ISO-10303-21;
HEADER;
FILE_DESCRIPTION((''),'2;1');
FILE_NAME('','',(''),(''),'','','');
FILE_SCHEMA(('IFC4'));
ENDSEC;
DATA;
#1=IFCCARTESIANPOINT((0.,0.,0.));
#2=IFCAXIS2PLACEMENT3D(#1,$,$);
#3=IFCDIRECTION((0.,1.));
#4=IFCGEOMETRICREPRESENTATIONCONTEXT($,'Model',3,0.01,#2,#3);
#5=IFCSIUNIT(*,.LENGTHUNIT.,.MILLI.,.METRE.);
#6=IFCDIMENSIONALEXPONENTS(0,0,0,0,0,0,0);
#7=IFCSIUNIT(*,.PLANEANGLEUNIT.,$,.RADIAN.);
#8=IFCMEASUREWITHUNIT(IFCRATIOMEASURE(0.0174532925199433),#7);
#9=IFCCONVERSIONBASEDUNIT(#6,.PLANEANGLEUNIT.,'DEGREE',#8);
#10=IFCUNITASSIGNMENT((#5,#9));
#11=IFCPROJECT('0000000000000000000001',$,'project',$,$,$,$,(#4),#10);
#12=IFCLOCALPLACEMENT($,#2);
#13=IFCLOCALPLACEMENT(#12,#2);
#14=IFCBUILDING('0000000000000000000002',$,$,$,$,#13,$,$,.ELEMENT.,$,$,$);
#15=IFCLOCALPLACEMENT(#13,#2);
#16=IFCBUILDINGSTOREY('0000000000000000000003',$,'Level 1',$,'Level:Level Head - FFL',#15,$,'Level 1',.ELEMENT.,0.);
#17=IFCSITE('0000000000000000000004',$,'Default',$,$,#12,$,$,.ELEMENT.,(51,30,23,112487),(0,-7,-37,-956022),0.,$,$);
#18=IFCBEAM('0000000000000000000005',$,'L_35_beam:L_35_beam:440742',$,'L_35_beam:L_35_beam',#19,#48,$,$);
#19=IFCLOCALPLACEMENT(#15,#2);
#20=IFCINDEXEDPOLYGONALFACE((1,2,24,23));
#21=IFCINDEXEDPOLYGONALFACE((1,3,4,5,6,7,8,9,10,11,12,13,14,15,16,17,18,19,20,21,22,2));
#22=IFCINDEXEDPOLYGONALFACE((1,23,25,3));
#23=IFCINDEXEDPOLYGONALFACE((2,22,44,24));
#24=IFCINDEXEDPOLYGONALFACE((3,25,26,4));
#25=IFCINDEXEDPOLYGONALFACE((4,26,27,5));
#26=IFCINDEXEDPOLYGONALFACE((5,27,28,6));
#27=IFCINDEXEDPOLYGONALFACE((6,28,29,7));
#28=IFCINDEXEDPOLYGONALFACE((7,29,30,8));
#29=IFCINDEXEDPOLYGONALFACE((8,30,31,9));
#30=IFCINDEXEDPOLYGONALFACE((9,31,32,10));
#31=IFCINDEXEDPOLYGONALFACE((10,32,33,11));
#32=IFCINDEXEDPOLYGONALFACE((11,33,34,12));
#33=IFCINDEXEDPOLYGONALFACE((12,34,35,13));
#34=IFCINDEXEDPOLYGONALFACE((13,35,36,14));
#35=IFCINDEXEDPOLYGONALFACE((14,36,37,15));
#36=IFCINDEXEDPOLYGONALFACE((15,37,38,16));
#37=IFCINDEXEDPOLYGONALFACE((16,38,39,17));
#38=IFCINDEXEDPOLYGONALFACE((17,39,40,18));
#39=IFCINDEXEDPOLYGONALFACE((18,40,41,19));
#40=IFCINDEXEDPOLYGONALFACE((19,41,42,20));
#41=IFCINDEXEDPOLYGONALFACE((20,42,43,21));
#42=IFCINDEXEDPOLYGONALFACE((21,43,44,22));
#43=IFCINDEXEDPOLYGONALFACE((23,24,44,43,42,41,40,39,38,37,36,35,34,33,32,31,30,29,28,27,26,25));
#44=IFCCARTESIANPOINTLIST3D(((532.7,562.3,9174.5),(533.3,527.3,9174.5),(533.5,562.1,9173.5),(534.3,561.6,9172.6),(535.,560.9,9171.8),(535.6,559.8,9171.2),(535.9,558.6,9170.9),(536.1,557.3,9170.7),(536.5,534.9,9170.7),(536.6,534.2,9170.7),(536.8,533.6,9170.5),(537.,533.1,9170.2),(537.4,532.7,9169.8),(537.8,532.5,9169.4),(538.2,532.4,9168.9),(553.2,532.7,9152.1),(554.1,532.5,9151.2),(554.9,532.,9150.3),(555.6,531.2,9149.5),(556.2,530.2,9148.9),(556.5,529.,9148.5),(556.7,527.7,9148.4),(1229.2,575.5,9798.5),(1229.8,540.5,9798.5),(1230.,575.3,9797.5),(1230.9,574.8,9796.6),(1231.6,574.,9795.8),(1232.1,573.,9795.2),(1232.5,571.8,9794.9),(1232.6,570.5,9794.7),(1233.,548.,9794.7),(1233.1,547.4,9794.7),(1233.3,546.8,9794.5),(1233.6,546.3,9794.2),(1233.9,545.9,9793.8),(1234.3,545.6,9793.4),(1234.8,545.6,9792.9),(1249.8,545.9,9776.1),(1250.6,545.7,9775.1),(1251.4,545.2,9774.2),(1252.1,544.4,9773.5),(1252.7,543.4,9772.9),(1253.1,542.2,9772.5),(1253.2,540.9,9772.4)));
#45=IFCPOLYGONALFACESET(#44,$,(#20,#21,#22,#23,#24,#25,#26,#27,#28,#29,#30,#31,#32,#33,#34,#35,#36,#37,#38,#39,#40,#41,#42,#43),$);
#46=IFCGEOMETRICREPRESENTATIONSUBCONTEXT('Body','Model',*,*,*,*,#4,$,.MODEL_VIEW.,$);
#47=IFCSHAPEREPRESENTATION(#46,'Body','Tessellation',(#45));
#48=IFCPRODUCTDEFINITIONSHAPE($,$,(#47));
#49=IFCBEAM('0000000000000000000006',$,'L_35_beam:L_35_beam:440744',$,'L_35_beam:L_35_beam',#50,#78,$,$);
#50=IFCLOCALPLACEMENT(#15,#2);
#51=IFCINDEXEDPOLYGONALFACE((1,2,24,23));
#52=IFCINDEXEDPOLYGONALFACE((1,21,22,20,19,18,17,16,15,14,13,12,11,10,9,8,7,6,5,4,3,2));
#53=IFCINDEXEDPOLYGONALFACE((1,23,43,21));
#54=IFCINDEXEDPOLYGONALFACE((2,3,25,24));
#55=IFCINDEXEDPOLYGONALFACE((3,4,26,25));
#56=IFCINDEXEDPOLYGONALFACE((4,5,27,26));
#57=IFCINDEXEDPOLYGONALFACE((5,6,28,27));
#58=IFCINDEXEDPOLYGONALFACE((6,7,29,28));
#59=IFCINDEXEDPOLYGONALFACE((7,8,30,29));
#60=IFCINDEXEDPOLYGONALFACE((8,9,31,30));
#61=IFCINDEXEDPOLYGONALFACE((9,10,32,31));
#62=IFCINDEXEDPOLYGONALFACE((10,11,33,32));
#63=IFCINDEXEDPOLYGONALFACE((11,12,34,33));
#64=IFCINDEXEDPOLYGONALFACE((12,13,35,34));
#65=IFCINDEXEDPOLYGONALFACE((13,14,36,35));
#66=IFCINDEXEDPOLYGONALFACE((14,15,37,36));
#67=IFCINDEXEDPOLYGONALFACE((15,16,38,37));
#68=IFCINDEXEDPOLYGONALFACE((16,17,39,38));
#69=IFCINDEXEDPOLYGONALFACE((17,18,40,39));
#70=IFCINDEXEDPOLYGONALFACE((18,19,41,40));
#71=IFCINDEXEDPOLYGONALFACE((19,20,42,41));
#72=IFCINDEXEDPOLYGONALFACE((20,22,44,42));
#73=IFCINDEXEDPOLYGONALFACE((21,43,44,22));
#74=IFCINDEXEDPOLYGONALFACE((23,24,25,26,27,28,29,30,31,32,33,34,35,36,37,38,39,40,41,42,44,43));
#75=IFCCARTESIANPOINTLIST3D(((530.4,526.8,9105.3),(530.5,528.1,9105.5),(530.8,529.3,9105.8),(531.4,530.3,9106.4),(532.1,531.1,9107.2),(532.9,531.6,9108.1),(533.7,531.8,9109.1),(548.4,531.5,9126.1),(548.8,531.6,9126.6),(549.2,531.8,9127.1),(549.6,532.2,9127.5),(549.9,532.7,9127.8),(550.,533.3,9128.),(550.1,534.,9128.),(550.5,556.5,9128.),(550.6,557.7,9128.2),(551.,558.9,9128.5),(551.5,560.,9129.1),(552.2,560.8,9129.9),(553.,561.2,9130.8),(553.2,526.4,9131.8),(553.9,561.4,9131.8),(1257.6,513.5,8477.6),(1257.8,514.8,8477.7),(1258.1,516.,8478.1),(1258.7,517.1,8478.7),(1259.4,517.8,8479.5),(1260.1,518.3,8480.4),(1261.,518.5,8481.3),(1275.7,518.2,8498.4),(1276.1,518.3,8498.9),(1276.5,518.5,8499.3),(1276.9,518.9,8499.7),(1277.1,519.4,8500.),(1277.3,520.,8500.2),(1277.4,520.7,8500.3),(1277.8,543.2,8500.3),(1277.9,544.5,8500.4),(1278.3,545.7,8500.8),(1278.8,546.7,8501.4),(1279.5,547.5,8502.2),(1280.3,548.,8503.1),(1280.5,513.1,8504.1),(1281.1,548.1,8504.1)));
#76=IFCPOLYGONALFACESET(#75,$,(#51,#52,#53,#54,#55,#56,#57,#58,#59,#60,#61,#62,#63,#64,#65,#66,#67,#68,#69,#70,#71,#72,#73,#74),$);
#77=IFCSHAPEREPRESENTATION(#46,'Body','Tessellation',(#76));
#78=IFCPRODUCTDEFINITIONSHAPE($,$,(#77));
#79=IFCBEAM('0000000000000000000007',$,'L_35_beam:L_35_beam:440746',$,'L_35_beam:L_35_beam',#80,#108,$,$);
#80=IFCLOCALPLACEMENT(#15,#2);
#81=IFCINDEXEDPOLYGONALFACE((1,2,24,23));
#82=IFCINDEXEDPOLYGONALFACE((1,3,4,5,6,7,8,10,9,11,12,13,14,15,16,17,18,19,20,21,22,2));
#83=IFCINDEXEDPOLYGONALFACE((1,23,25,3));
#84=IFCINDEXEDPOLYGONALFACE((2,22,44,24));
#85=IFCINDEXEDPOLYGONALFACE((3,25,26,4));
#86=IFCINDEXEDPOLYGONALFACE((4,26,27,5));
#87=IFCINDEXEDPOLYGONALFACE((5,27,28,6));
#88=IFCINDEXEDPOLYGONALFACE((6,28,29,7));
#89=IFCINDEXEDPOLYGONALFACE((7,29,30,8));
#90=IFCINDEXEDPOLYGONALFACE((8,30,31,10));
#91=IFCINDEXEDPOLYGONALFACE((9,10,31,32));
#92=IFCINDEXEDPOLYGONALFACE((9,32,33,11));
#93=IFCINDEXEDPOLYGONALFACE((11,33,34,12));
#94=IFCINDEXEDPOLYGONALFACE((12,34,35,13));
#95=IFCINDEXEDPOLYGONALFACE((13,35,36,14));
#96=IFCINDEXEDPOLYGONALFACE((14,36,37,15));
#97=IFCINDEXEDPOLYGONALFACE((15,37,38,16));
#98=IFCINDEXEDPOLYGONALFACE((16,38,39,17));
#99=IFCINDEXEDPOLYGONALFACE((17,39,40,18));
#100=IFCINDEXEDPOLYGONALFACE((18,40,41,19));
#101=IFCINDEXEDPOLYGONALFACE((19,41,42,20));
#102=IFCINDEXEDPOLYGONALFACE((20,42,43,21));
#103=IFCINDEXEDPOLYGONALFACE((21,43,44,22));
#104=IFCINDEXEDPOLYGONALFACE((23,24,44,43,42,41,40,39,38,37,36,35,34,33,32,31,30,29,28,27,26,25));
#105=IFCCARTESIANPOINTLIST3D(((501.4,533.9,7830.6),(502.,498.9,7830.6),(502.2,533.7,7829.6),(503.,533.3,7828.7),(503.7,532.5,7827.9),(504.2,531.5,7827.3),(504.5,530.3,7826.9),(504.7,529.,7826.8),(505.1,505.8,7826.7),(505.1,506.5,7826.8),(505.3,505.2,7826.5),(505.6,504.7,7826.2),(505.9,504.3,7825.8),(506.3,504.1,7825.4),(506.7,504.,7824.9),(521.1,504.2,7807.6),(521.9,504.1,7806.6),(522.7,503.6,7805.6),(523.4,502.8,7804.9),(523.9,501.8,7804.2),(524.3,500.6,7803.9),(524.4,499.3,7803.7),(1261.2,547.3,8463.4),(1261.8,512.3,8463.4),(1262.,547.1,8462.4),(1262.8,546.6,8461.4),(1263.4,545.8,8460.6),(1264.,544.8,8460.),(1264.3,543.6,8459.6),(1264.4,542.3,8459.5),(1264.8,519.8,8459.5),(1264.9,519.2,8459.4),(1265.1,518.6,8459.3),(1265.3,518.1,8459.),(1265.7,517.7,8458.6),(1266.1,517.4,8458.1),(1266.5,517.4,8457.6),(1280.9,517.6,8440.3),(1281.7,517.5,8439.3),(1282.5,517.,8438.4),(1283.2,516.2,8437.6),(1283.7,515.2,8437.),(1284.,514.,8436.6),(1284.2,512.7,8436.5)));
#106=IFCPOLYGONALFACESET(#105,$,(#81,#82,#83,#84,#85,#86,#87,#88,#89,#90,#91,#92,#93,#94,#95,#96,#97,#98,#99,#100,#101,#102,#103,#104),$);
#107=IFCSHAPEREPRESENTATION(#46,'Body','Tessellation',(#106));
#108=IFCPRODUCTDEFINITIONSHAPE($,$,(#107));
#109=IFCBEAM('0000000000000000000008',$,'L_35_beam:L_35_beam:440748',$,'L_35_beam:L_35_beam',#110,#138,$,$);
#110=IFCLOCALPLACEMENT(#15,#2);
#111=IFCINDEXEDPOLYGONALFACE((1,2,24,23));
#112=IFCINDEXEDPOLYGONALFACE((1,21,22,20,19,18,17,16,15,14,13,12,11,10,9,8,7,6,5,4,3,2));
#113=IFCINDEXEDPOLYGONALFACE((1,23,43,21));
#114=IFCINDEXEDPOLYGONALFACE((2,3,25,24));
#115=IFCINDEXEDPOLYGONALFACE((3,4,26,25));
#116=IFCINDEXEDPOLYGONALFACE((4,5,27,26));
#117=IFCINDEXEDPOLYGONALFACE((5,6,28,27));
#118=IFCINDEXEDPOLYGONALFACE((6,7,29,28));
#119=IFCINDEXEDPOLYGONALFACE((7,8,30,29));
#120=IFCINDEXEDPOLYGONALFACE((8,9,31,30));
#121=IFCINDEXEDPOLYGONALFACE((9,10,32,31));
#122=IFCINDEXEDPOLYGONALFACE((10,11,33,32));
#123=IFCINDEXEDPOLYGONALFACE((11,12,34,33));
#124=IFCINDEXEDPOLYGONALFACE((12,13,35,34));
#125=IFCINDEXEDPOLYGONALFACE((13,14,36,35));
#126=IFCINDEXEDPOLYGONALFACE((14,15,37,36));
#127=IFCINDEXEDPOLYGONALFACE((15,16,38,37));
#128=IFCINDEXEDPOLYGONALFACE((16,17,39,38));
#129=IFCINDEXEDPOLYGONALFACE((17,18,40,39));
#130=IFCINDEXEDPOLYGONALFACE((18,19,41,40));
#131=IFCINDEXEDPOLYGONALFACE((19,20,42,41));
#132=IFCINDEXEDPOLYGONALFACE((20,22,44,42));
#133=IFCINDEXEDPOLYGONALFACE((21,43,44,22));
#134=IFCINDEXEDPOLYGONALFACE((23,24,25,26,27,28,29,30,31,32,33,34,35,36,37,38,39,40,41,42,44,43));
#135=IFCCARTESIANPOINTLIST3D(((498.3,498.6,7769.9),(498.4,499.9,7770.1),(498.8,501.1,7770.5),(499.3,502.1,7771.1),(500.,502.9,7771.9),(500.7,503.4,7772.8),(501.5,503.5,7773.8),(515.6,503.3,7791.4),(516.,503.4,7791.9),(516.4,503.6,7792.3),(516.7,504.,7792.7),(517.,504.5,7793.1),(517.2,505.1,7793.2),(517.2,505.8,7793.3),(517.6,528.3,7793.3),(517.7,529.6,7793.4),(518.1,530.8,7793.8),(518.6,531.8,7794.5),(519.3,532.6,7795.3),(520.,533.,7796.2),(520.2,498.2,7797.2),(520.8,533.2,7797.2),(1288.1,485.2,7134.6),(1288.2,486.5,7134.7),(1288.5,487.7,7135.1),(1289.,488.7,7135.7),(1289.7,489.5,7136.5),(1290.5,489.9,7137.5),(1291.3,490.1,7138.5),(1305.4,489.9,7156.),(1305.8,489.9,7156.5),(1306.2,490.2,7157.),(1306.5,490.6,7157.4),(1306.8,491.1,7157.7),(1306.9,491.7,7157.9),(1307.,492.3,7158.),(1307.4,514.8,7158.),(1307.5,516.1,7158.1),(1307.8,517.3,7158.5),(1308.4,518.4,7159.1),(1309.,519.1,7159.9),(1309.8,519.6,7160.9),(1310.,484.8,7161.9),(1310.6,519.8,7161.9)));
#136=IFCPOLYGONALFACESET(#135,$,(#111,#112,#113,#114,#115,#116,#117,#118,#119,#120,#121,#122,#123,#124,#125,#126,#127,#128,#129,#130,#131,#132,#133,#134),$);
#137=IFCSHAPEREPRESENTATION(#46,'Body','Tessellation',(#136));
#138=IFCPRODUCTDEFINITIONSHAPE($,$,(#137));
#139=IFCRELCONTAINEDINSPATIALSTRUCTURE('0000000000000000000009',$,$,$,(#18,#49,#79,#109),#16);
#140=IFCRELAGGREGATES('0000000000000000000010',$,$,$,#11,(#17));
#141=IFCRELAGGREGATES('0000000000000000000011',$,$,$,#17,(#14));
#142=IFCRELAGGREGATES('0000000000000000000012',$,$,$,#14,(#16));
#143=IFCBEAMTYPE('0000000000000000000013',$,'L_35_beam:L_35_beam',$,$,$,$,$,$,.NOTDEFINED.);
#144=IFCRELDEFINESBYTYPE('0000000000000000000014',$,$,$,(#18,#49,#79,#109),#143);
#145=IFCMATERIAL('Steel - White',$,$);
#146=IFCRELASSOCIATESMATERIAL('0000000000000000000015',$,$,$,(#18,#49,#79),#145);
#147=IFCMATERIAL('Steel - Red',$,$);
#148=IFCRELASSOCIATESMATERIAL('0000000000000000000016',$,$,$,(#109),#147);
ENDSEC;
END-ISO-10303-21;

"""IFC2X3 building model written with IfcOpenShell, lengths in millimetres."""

from ifc_helpers import new_model, entity, si_unit, converted_unit, direction, frame, frame_2d, origin, place, context, subcontext, project, spatial, polyline, circle_curve, parameter, trimmed, segment, composite_curve, outline, extrude, material, type_object, element, save


model = new_model("IFC2X3")

# Units and contexts
model_context = context("Model", 3, precision=0.01, world=origin(), true_north=direction((0.0, 1.0)))
body_context = subcontext(model_context, "Body", "Model", "MODEL_VIEW")
ifc_project = project(units=[si_unit("LENGTHUNIT", "METRE", prefix="MILLI"), converted_unit("PLANEANGLEUNIT", "DEGREE", entity("IfcRatioMeasure", 0.0174532925199433), si_unit("PLANEANGLEUNIT", "RADIAN"), dimensions=[0, 0, 0, 0, 0, 0, 0])], contexts=[model_context])

# Site, building, storey
site_placement = place(None, origin())
site = spatial("IfcSite", under=ifc_project, at=site_placement, Name="Default", CompositionType="ELEMENT", RefLatitude=(51, 30, 23, 112487), RefLongitude=(0, -7, -37, -956022), RefElevation=0.0)
building_placement = place(site_placement, origin())
building = spatial("IfcBuilding", under=site, at=building_placement, CompositionType="ELEMENT")
storey_placement = place(building_placement, origin())
storey = spatial("IfcBuildingStorey", under=building, at=storey_placement, Name="Level 1", ObjectType="Level:Level Head - FFL", LongName="Level 1", CompositionType="ELEMENT", Elevation=0.0)

# Beams
ifc_material_1 = material(Name="Steel - Red")
ifc_material_2 = material(Name="Steel - White")
beam_type_1 = type_object("IfcBeamType", Name="L_35_beam:L_35_beam", PredefinedType="NOTDEFINED")
beam_1_placement = place(storey_placement, frame((1266.8, 533.2, 9807.9), z_axis=(-0.66707, -0.012627, 0.744888), x_axis=(-0.744755, -0.014097, -0.667189)))
element("IfcBeam", 1, at=beam_1_placement, inside=storey, type_object=beam_type_1, material=ifc_material_2, Name="L_35_beam:L_35_beam:440742", ObjectType="L_35_beam:L_35_beam", context=body_context, shape_type="SweptSolid", body=[
    extrude(outline(composite_curve([segment(polyline([(-23.2, -11.8), (11.8, -11.8)]), True, "CONTINUOUS"), segment(polyline([(11.8, -11.8), (11.8, 23.2)]), True, "CONTINUOUS"), segment(trimmed(circle_curve(frame_2d((11.8, 18.2), x_axis=(0.0, 1.0)), 5.0), [parameter(0.0)], [parameter(90.0)], True, "PARAMETER"), True, "CONTINUOUS"), segment(polyline([(6.8, 18.2), (6.8, -4.3)]), True, "CONTINUOUS"), segment(trimmed(circle_curve(frame_2d((4.3, -4.3), x_axis=(1.0, 0.0)), 2.5), [parameter(270.0)], [parameter(0.0)], True, "PARAMETER"), False, "CONTINUOUS"), segment(polyline([(4.3, -6.8), (-18.2, -6.8)]), True, "CONTINUOUS"), segment(trimmed(circle_curve(frame_2d((-18.2, -11.8), x_axis=(0.0, 1.0)), 5.0), [parameter(0.0)], [parameter(90.0)], True, "PARAMETER"), True, "CONTINUOUS")], self_intersect=False)), frame((33.7, -19.8, 5.7), z_axis=(1.0, 0.0, 0.0), x_axis=(0.0, 0.0, 1.0)), (0.0, 0.0, 1.0), 935.2),
])
beam_2_placement = place(storey_placement, frame((1295.1, 504.9, 8468.2), z_axis=(0.653245, -0.011914, 0.757053), x_axis=(-0.756927, 0.013805, 0.653353)))
element("IfcBeam", 2, at=beam_2_placement, inside=storey, type_object=beam_type_1, material=ifc_material_2, Name="L_35_beam:L_35_beam:440744", ObjectType="L_35_beam:L_35_beam", context=body_context, shape_type="SweptSolid", body=[
    extrude(outline(composite_curve([segment(polyline([(-23.2, -11.8), (11.8, -11.8)]), True, "CONTINUOUS"), segment(polyline([(11.8, -11.8), (11.8, 23.2)]), True, "CONTINUOUS"), segment(trimmed(circle_curve(frame_2d((11.8, 18.2), x_axis=(0.0, 1.0)), 5.0), [parameter(0.0)], [parameter(90.0)], True, "PARAMETER"), True, "CONTINUOUS"), segment(polyline([(6.8, 18.2), (6.8, -4.3)]), True, "CONTINUOUS"), segment(trimmed(circle_curve(frame_2d((4.3, -4.3), x_axis=(1.0, 0.0)), 2.5), [parameter(270.0)], [parameter(0.0)], True, "PARAMETER"), False, "CONTINUOUS"), segment(polyline([(4.3, -6.8), (-18.2, -6.8)]), True, "CONTINUOUS"), segment(trimmed(circle_curve(frame_2d((-18.2, -11.8), x_axis=(0.0, 1.0)), 5.0), [parameter(0.0)], [parameter(90.0)], True, "PARAMETER"), True, "CONTINUOUS")], self_intersect=False)), frame((34.6, -19.8, 5.7), z_axis=(1.0, 0.0, 0.0), x_axis=(0.0, 0.0, 1.0)), (0.0, 0.0, 1.0), 960.8),
])
beam_3_placement = place(storey_placement, frame((1295.1, 504.9, 8468.2), z_axis=(-0.639777, -0.011258, 0.768478), x_axis=(-0.768359, -0.01352, -0.639876)))
element("IfcBeam", 3, at=beam_3_placement, inside=storey, type_object=beam_type_1, material=ifc_material_2, Name="L_35_beam:L_35_beam:440746", ObjectType="L_35_beam:L_35_beam", context=body_context, shape_type="SweptSolid", body=[
    extrude(outline(composite_curve([segment(polyline([(-23.2, -11.8), (11.8, -11.8)]), True, "CONTINUOUS"), segment(polyline([(11.8, -11.8), (11.8, 23.2)]), True, "CONTINUOUS"), segment(trimmed(circle_curve(frame_2d((11.8, 18.2), x_axis=(0.0, 1.0)), 5.0), [parameter(0.0)], [parameter(90.0)], True, "PARAMETER"), True, "CONTINUOUS"), segment(polyline([(6.8, 18.2), (6.8, -4.3)]), True, "CONTINUOUS"), segment(trimmed(circle_curve(frame_2d((4.3, -4.3), x_axis=(1.0, 0.0)), 2.5), [parameter(270.0)], [parameter(0.0)], True, "PARAMETER"), False, "CONTINUOUS"), segment(polyline([(4.3, -6.8), (-18.2, -6.8)]), True, "CONTINUOUS"), segment(trimmed(circle_curve(frame_2d((-18.2, -11.8), x_axis=(0.0, 1.0)), 5.0), [parameter(0.0)], [parameter(90.0)], True, "PARAMETER"), True, "CONTINUOUS")], self_intersect=False)), frame((28.6, -19.8, 5.7), z_axis=(1.0, 0.0, 0.0), x_axis=(0.0, 0.0, 1.0)), (0.0, 0.0, 1.0), 988.8),
])
beam_4_placement = place(storey_placement, frame((1323.4, 476.6, 7128.5), z_axis=(0.626668, -0.010652, 0.779213), x_axis=(-0.779101, 0.013243, 0.626759)))
element("IfcBeam", 4, at=beam_4_placement, inside=storey, type_object=beam_type_1, material=ifc_material_1, Name="L_35_beam:L_35_beam:440748", ObjectType="L_35_beam:L_35_beam", context=body_context, shape_type="SweptSolid", body=[
    extrude(outline(composite_curve([segment(polyline([(-23.2, -11.8), (11.8, -11.8)]), True, "CONTINUOUS"), segment(polyline([(11.8, -11.8), (11.8, 23.2)]), True, "CONTINUOUS"), segment(trimmed(circle_curve(frame_2d((11.8, 18.2), x_axis=(0.0, 1.0)), 5.0), [parameter(0.0)], [parameter(90.0)], True, "PARAMETER"), True, "CONTINUOUS"), segment(polyline([(6.8, 18.2), (6.8, -4.3)]), True, "CONTINUOUS"), segment(trimmed(circle_curve(frame_2d((4.3, -4.3), x_axis=(1.0, 0.0)), 2.5), [parameter(270.0)], [parameter(0.0)], True, "PARAMETER"), False, "CONTINUOUS"), segment(polyline([(4.3, -6.8), (-18.2, -6.8)]), True, "CONTINUOUS"), segment(trimmed(circle_curve(frame_2d((-18.2, -11.8), x_axis=(0.0, 1.0)), 5.0), [parameter(0.0)], [parameter(90.0)], True, "PARAMETER"), True, "CONTINUOUS")], self_intersect=False)), frame((31.5, -19.8, 5.7), z_axis=(1.0, 0.0, 0.0), x_axis=(0.0, 0.0, 1.0)), (0.0, 0.0, 1.0), 1013.7),
])

save(model, "model.ifc")
